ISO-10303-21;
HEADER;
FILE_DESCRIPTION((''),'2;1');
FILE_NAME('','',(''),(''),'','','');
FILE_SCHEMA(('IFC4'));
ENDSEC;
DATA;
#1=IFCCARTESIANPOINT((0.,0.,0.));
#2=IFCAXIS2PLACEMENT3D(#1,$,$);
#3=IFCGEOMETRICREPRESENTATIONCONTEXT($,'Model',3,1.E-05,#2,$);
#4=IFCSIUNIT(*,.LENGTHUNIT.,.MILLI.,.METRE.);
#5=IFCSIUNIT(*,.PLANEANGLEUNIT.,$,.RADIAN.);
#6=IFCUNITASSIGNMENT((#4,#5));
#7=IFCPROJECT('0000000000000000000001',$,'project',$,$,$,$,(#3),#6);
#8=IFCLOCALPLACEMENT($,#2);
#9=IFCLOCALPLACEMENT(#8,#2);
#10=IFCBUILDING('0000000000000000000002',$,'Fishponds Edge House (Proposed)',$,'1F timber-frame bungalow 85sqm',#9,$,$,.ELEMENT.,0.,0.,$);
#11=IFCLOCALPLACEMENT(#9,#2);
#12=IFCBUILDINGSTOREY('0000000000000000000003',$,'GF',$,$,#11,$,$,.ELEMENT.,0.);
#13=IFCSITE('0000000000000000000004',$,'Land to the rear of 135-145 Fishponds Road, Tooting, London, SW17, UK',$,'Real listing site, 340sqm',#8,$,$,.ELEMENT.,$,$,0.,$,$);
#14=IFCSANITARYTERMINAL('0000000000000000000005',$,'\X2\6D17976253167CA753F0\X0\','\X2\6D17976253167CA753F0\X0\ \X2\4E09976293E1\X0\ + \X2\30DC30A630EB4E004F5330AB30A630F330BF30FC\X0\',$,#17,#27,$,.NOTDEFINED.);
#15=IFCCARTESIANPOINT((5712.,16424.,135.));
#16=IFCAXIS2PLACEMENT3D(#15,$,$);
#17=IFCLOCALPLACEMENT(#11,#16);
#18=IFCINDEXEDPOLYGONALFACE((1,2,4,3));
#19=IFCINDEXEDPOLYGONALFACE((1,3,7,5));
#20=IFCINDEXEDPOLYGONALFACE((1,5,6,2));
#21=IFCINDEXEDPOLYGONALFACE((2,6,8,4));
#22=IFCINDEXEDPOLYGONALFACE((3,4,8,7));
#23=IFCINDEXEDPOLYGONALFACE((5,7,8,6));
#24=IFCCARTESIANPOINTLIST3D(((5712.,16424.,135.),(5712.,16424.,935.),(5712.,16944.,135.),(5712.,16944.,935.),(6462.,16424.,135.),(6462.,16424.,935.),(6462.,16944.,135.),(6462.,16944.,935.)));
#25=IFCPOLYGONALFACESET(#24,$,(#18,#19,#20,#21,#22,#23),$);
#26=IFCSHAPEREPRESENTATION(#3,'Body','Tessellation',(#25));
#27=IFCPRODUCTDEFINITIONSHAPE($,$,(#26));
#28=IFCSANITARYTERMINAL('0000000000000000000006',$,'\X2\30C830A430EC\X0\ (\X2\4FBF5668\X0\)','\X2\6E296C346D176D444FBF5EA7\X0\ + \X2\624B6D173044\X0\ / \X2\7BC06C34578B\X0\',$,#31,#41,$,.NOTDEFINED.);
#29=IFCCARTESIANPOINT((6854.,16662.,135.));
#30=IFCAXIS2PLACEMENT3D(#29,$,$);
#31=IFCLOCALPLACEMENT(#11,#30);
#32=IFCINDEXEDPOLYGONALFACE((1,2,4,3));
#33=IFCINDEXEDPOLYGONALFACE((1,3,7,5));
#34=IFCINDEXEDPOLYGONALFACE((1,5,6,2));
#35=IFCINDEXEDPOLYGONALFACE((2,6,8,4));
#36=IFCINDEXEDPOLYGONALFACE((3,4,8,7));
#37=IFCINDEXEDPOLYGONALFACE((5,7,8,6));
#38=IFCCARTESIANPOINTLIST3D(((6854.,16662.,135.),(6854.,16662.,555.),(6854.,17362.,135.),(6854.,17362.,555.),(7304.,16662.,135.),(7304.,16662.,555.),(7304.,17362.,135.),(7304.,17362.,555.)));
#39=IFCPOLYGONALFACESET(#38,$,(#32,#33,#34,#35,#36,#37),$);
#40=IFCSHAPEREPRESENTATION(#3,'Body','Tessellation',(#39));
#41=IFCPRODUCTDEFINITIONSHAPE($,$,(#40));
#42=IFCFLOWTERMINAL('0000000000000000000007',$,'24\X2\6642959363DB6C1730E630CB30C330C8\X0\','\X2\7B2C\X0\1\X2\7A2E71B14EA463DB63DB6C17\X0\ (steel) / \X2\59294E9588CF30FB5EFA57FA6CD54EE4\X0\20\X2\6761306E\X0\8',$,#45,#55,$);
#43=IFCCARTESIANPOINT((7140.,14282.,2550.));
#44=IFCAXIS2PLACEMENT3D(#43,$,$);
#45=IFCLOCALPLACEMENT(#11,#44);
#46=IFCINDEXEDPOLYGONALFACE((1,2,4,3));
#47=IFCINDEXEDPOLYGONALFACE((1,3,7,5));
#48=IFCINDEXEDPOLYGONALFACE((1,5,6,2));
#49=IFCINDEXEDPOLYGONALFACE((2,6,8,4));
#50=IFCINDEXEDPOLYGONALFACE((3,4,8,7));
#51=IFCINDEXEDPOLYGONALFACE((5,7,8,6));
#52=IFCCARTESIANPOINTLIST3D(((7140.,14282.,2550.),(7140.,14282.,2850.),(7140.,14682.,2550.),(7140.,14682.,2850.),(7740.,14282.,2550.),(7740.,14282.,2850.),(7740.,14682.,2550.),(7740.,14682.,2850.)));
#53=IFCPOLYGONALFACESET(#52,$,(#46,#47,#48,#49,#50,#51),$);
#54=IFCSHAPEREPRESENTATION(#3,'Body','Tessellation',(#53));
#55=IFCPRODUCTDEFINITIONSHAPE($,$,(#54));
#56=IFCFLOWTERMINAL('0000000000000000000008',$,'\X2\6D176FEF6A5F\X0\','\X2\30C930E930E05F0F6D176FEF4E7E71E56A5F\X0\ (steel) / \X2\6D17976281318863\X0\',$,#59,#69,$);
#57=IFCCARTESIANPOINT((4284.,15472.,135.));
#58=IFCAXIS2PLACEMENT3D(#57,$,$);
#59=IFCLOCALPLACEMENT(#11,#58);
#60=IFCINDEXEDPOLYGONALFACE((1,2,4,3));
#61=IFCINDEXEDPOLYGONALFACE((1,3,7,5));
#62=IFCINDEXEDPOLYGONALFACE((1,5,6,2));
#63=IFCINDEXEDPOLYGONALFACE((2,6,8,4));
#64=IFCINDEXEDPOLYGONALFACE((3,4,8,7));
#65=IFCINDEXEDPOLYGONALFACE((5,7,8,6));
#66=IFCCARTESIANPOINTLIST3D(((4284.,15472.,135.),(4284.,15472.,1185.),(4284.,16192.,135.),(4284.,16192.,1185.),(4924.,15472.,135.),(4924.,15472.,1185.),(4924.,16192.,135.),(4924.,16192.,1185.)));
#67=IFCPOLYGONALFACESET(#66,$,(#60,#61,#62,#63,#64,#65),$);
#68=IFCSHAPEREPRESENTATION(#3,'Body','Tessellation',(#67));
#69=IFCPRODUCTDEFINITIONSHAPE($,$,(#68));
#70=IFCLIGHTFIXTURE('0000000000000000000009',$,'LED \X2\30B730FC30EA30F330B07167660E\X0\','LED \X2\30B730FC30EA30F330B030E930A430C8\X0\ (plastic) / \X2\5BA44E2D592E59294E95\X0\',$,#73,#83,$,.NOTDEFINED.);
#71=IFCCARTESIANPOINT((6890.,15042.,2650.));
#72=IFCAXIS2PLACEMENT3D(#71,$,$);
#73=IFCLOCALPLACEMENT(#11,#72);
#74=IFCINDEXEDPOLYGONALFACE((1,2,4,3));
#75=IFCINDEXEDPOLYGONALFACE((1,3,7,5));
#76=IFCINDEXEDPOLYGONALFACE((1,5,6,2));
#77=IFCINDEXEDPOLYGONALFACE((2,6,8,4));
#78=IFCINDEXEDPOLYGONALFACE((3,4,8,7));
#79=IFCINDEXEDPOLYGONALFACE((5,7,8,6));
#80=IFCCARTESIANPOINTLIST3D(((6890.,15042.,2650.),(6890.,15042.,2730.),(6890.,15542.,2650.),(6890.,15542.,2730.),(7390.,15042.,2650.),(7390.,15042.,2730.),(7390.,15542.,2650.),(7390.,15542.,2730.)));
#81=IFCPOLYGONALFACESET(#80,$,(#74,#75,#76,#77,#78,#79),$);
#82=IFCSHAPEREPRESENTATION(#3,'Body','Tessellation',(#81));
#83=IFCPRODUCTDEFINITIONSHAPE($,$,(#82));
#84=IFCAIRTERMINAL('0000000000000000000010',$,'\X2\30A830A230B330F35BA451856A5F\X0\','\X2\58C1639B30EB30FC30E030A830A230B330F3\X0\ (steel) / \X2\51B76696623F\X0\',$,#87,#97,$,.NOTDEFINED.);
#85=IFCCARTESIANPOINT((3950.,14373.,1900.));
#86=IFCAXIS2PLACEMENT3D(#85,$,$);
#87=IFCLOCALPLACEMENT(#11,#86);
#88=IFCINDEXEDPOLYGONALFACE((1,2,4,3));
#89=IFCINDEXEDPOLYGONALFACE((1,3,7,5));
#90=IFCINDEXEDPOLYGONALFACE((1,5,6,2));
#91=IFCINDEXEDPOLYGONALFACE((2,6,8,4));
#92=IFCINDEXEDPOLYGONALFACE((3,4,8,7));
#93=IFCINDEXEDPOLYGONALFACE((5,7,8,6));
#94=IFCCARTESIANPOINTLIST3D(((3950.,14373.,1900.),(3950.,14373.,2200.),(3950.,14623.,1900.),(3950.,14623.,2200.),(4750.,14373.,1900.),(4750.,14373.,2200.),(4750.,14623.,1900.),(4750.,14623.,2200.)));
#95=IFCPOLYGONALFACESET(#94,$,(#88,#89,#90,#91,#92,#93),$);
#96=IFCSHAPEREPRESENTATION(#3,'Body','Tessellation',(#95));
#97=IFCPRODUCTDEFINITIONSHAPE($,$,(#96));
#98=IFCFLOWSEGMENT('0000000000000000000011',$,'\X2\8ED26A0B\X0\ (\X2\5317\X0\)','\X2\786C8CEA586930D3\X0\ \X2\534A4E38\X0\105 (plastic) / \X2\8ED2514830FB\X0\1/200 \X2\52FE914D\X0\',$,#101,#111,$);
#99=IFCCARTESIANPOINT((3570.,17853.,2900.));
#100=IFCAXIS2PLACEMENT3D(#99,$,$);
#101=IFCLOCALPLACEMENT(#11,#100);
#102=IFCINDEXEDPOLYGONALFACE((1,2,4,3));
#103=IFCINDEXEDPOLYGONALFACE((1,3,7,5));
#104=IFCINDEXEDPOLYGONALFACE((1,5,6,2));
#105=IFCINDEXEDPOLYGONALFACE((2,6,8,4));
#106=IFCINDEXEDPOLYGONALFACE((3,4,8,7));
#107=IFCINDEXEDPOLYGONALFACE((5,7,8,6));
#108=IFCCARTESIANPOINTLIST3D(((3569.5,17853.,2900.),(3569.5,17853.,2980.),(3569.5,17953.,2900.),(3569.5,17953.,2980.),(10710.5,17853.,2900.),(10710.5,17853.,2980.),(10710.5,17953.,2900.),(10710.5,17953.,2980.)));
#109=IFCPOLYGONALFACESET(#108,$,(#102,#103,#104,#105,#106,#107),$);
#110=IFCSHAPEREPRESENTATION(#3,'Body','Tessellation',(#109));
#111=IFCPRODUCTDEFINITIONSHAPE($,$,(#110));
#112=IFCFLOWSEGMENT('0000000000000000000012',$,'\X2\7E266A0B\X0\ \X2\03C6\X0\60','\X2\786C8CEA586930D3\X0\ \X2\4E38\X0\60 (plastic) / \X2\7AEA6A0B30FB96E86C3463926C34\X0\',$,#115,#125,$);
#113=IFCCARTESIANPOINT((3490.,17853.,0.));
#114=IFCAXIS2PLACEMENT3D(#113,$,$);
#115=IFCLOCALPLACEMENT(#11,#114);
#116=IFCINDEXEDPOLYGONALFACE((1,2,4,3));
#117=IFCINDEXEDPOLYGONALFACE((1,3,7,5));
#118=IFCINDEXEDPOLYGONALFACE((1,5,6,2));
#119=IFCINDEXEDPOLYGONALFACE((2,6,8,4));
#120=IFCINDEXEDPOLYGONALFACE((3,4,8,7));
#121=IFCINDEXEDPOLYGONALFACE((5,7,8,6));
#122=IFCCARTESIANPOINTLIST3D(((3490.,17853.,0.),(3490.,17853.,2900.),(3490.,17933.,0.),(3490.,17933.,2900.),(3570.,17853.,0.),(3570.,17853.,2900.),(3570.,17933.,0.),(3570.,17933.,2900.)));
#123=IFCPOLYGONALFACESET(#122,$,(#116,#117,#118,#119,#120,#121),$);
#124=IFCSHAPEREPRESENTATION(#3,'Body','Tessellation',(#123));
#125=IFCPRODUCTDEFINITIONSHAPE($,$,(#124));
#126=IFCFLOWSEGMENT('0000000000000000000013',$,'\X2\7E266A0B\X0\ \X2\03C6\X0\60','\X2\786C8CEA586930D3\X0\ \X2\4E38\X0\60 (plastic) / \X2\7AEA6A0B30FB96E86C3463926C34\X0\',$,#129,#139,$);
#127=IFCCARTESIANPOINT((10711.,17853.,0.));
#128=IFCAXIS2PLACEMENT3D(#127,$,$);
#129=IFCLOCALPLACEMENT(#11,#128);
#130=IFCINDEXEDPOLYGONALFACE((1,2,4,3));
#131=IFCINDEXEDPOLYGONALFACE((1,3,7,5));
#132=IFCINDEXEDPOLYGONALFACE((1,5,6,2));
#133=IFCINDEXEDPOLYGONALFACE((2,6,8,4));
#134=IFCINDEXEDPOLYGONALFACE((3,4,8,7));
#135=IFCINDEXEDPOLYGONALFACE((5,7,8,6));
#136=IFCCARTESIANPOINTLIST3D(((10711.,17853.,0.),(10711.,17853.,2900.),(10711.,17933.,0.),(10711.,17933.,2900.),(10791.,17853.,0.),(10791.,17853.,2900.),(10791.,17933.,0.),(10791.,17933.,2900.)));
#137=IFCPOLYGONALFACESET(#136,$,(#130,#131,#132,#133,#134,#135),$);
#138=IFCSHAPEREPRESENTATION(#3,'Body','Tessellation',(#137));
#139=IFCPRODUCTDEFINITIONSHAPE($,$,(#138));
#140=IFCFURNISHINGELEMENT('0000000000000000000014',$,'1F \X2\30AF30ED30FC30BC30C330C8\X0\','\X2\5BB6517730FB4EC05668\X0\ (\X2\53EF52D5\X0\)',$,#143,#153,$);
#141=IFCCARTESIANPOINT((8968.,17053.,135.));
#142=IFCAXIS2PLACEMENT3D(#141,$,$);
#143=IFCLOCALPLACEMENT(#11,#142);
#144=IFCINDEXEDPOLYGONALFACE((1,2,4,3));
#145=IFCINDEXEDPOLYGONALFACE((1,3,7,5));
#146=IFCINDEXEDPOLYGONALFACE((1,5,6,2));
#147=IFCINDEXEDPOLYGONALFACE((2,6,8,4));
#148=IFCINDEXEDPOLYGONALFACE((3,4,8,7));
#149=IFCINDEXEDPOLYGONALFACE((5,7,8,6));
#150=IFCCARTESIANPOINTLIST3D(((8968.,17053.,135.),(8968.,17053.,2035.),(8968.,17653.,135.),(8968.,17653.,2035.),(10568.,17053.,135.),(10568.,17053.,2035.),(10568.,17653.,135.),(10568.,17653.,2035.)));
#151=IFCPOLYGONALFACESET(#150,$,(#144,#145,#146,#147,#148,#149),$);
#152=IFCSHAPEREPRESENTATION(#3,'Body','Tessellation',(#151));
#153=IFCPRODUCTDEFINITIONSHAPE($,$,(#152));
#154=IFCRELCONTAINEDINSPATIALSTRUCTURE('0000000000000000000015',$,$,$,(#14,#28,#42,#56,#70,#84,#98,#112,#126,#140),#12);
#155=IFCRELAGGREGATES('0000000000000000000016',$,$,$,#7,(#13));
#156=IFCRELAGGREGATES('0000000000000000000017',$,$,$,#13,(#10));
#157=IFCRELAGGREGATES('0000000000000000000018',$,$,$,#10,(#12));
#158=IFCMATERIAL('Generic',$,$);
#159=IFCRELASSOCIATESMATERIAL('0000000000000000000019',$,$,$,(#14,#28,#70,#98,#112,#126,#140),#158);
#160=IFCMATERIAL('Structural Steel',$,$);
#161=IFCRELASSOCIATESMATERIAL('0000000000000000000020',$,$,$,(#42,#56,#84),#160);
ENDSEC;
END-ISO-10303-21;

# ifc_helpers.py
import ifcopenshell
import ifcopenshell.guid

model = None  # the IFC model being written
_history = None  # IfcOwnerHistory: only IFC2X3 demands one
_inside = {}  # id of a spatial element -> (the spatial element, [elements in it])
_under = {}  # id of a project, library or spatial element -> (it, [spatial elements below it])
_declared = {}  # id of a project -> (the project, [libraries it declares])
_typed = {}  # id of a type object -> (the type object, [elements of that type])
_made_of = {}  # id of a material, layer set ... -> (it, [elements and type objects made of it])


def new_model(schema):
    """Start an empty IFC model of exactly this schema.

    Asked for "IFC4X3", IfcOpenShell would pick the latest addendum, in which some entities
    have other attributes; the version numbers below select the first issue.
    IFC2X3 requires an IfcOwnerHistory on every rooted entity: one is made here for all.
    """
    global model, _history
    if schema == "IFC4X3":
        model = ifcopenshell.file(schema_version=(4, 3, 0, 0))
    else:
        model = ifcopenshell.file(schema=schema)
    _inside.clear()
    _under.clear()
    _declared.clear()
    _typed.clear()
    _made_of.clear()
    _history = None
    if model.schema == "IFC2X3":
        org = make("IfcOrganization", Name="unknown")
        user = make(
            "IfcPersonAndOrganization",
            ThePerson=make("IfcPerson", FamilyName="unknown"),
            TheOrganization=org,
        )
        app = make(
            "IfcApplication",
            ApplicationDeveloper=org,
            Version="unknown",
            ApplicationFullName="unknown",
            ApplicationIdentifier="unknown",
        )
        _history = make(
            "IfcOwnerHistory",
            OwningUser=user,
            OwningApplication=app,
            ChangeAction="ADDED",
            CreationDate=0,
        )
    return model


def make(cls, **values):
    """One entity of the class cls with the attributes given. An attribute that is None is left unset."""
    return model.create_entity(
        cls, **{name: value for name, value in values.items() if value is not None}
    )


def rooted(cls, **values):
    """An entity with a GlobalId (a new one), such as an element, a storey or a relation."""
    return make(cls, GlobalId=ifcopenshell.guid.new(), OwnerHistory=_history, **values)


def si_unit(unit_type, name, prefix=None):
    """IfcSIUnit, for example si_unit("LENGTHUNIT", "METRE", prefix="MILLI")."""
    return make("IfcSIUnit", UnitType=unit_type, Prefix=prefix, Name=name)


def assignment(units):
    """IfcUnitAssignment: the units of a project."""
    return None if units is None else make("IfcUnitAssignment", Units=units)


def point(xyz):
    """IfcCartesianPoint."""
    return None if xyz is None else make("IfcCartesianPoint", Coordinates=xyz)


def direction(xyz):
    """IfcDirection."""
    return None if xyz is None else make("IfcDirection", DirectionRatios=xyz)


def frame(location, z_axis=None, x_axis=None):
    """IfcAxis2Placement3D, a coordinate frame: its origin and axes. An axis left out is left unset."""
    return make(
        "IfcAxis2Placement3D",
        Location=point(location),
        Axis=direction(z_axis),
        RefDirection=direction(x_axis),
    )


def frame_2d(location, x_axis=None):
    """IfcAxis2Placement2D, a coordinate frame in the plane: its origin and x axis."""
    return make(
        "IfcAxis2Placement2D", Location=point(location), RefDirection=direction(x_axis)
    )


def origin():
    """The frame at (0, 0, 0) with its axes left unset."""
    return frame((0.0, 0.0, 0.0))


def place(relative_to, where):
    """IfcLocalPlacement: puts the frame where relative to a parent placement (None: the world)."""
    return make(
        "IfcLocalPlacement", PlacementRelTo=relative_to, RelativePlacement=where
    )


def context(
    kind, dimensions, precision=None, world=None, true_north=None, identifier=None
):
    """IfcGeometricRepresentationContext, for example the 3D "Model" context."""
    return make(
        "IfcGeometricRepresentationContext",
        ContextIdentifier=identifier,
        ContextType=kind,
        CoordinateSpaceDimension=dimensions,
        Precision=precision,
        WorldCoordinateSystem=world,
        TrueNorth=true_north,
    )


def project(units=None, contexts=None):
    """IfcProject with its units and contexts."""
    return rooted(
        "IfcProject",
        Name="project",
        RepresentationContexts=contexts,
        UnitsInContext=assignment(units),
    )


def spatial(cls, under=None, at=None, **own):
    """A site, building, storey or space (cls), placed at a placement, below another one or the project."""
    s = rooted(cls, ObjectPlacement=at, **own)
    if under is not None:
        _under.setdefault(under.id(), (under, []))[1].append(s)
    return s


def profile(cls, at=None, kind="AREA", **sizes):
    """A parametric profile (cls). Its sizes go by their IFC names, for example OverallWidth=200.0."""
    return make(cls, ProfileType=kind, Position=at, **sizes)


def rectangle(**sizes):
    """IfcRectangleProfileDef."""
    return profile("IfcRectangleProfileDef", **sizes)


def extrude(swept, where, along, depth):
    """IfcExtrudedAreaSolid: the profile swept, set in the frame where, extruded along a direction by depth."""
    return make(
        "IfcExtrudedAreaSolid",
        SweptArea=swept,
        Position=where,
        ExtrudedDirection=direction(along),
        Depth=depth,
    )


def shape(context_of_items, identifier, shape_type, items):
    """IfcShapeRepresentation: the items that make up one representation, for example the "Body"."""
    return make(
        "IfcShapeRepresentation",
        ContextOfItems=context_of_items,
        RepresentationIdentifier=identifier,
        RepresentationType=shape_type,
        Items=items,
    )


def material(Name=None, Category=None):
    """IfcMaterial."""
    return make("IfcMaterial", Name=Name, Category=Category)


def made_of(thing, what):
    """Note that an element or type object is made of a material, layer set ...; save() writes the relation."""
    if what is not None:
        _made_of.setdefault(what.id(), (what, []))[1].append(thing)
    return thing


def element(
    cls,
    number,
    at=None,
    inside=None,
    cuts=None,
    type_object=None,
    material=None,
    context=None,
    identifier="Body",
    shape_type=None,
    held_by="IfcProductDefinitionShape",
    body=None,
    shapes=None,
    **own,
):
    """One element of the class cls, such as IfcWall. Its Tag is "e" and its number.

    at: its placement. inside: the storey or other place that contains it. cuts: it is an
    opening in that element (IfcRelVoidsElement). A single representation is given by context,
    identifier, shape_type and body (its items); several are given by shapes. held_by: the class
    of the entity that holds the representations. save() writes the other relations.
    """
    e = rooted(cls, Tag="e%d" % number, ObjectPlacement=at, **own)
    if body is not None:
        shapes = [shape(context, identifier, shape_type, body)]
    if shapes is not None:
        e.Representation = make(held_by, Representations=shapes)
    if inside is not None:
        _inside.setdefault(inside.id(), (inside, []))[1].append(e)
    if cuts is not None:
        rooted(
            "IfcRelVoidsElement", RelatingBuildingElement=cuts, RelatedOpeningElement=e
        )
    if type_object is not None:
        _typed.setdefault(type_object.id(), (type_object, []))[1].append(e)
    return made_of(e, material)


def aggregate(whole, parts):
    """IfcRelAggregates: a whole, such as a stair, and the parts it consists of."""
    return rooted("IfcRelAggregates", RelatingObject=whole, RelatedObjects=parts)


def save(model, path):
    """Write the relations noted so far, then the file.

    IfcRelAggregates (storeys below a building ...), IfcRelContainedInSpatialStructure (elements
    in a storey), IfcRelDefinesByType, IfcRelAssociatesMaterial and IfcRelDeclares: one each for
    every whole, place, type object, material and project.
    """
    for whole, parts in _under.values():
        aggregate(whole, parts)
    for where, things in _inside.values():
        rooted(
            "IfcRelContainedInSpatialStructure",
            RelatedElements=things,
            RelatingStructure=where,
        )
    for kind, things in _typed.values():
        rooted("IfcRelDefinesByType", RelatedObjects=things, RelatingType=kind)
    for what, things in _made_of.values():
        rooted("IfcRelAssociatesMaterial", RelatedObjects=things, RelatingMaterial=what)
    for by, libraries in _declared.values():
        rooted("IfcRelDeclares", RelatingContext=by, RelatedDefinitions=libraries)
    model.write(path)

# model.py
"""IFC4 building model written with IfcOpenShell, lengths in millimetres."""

from ifc_helpers import new_model, si_unit, frame, frame_2d, origin, place, context, project, spatial, rectangle, extrude, material, element, save


model = new_model("IFC4")

# Units and contexts
model_context = context("Model", 3, precision=1e-05, world=origin())
ifc_project = project(units=[si_unit("LENGTHUNIT", "METRE", prefix="MILLI"), si_unit("PLANEANGLEUNIT", "RADIAN")], contexts=[model_context])

# Site, building, storey
site_placement = place(None, origin())
site = spatial("IfcSite", under=ifc_project, at=site_placement, Name="Land to the rear of 135-145 Fishponds Road, Tooting, London, SW17, UK", ObjectType="Real listing site, 340sqm", CompositionType="ELEMENT", RefElevation=0.0)
building_placement = place(site_placement, origin())
building = spatial("IfcBuilding", under=site, at=building_placement, Name="Fishponds Edge House (Proposed)", ObjectType="1F timber-frame bungalow 85sqm", CompositionType="ELEMENT", ElevationOfRefHeight=0.0, ElevationOfTerrain=0.0)
storey_placement = place(building_placement, origin())
storey = spatial("IfcBuildingStorey", under=building, at=storey_placement, Name="GF", CompositionType="ELEMENT", Elevation=0.0)

# Shared definitions
ifc_material_1 = material(Name="Generic")

# Sanitary terminals
sanitary_terminal_1_placement = place(storey_placement, frame((5712.0, 16424.0, 135.0)))
element("IfcSanitaryTerminal", 1, at=sanitary_terminal_1_placement, inside=storey, material=ifc_material_1, Name="洗面化粧台", Description="洗面化粧台 三面鏡 + ボウル一体カウンター", PredefinedType="NOTDEFINED", context=model_context, shape_type="SweptSolid", body=[
    extrude(rectangle(XDim=750.0, YDim=520.0, at=frame_2d((375.0, 260.0))), frame((5712.0, 16424.0, 135.0)), (0.0, 0.0, 1.0), 800.0),
])
sanitary_terminal_2_placement = place(storey_placement, frame((6854.0, 16662.0, 135.0)))
element("IfcSanitaryTerminal", 2, at=sanitary_terminal_2_placement, inside=storey, material=ifc_material_1, Name="トイレ (便器)", Description="温水洗浄便座 + 手洗い / 節水型", PredefinedType="NOTDEFINED", context=model_context, shape_type="SweptSolid", body=[
    extrude(rectangle(XDim=450.0, YDim=700.0, at=frame_2d((225.0, 350.0))), frame((6854.0, 16662.0, 135.0)), (0.0, 0.0, 1.0), 420.0),
])

# Flow terminals
ifc_material_2 = material(Name="Structural Steel")
flow_terminal_1_placement = place(storey_placement, frame((7140.0, 14282.0, 2550.0)))
element("IfcFlowTerminal", 3, at=flow_terminal_1_placement, inside=storey, material=ifc_material_2, Name="24時間換気ユニット", Description="第1種熱交換換気 (steel) / 天井裏・建基法令20条の8", context=model_context, shape_type="SweptSolid", body=[
    extrude(rectangle(XDim=600.0, YDim=400.0, at=frame_2d((300.0, 200.0))), frame((7140.0, 14282.0, 2550.0)), (0.0, 0.0, 1.0), 300.0),
])
flow_terminal_2_placement = place(storey_placement, frame((4284.0, 15472.0, 135.0)))
element("IfcFlowTerminal", 4, at=flow_terminal_2_placement, inside=storey, material=ifc_material_2, Name="洗濯機", Description="ドラム式洗濯乾燥機 (steel) / 洗面脱衣", context=model_context, shape_type="SweptSolid", body=[
    extrude(rectangle(XDim=640.0, YDim=720.0, at=frame_2d((320.0, 360.0))), frame((4284.0, 15472.0, 135.0)), (0.0, 0.0, 1.0), 1050.0),
])

# Light fixture
light_fixture_placement = place(storey_placement, frame((6890.0, 15042.0, 2650.0)))
element("IfcLightFixture", 5, at=light_fixture_placement, inside=storey, material=ifc_material_1, Name="LED シーリング照明", Description="LED シーリングライト (plastic) / 室中央天井", PredefinedType="NOTDEFINED", context=model_context, shape_type="SweptSolid", body=[
    extrude(rectangle(XDim=500.0, YDim=500.0, at=frame_2d((250.0, 250.0))), frame((6890.0, 15042.0, 2650.0)), (0.0, 0.0, 1.0), 80.0),
])

# Air terminal
air_terminal_placement = place(storey_placement, frame((3950.0, 14373.0, 1900.0)))
element("IfcAirTerminal", 6, at=air_terminal_placement, inside=storey, material=ifc_material_2, Name="エアコン室内機", Description="壁掛ルームエアコン (steel) / 冷暖房", PredefinedType="NOTDEFINED", context=model_context, shape_type="SweptSolid", body=[
    extrude(rectangle(XDim=800.0, YDim=250.0, at=frame_2d((400.0, 125.0))), frame((3950.0, 14373.0, 1900.0)), (0.0, 0.0, 1.0), 300.0),
])

# Flow segments
flow_segment_1_placement = place(storey_placement, frame((3570.0, 17853.0, 2900.0)))
element("IfcFlowSegment", 7, at=flow_segment_1_placement, inside=storey, material=ifc_material_1, Name="軒樋 (北)", Description="硬質塩ビ 半丸105 (plastic) / 軒先・1/200 勾配", context=model_context, shape_type="SweptSolid", body=[
    extrude(rectangle(XDim=7141.0, YDim=100.0, at=frame_2d((3570.0, 50.0))), frame((3570.0, 17853.0, 2900.0)), (0.0, 0.0, 1.0), 80.0),
])
flow_segment_2_placement = place(storey_placement, frame((3490.0, 17853.0, 0.0)))
element("IfcFlowSegment", 8, at=flow_segment_2_placement, inside=storey, material=ifc_material_1, Name="縦樋 φ60", Description="硬質塩ビ 丸60 (plastic) / 竪樋・雨水排水", context=model_context, shape_type="SweptSolid", body=[
    extrude(rectangle(XDim=80.0, YDim=80.0, at=frame_2d((40.0, 40.0))), frame((3490.0, 17853.0, 0.0)), (0.0, 0.0, 1.0), 2900.0),
])
flow_segment_3_placement = place(storey_placement, frame((10711.0, 17853.0, 0.0)))
element("IfcFlowSegment", 9, at=flow_segment_3_placement, inside=storey, material=ifc_material_1, Name="縦樋 φ60", Description="硬質塩ビ 丸60 (plastic) / 竪樋・雨水排水", context=model_context, shape_type="SweptSolid", body=[
    extrude(rectangle(XDim=80.0, YDim=80.0, at=frame_2d((40.0, 40.0))), frame((10711.0, 17853.0, 0.0)), (0.0, 0.0, 1.0), 2900.0),
])

# Furnishing element
furnishing_placement = place(storey_placement, frame((8968.0, 17053.0, 135.0)))
element("IfcFurnishingElement", 10, at=furnishing_placement, inside=storey, material=ifc_material_1, Name="1F クローゼット", Description="家具・什器 (可動)", context=model_context, shape_type="SweptSolid", body=[
    extrude(rectangle(XDim=1600.0, YDim=600.0, at=frame_2d((800.0, 300.0))), frame((8968.0, 17053.0, 135.0)), (0.0, 0.0, 1.0), 1900.0),
])

save(model, "model.ifc")
